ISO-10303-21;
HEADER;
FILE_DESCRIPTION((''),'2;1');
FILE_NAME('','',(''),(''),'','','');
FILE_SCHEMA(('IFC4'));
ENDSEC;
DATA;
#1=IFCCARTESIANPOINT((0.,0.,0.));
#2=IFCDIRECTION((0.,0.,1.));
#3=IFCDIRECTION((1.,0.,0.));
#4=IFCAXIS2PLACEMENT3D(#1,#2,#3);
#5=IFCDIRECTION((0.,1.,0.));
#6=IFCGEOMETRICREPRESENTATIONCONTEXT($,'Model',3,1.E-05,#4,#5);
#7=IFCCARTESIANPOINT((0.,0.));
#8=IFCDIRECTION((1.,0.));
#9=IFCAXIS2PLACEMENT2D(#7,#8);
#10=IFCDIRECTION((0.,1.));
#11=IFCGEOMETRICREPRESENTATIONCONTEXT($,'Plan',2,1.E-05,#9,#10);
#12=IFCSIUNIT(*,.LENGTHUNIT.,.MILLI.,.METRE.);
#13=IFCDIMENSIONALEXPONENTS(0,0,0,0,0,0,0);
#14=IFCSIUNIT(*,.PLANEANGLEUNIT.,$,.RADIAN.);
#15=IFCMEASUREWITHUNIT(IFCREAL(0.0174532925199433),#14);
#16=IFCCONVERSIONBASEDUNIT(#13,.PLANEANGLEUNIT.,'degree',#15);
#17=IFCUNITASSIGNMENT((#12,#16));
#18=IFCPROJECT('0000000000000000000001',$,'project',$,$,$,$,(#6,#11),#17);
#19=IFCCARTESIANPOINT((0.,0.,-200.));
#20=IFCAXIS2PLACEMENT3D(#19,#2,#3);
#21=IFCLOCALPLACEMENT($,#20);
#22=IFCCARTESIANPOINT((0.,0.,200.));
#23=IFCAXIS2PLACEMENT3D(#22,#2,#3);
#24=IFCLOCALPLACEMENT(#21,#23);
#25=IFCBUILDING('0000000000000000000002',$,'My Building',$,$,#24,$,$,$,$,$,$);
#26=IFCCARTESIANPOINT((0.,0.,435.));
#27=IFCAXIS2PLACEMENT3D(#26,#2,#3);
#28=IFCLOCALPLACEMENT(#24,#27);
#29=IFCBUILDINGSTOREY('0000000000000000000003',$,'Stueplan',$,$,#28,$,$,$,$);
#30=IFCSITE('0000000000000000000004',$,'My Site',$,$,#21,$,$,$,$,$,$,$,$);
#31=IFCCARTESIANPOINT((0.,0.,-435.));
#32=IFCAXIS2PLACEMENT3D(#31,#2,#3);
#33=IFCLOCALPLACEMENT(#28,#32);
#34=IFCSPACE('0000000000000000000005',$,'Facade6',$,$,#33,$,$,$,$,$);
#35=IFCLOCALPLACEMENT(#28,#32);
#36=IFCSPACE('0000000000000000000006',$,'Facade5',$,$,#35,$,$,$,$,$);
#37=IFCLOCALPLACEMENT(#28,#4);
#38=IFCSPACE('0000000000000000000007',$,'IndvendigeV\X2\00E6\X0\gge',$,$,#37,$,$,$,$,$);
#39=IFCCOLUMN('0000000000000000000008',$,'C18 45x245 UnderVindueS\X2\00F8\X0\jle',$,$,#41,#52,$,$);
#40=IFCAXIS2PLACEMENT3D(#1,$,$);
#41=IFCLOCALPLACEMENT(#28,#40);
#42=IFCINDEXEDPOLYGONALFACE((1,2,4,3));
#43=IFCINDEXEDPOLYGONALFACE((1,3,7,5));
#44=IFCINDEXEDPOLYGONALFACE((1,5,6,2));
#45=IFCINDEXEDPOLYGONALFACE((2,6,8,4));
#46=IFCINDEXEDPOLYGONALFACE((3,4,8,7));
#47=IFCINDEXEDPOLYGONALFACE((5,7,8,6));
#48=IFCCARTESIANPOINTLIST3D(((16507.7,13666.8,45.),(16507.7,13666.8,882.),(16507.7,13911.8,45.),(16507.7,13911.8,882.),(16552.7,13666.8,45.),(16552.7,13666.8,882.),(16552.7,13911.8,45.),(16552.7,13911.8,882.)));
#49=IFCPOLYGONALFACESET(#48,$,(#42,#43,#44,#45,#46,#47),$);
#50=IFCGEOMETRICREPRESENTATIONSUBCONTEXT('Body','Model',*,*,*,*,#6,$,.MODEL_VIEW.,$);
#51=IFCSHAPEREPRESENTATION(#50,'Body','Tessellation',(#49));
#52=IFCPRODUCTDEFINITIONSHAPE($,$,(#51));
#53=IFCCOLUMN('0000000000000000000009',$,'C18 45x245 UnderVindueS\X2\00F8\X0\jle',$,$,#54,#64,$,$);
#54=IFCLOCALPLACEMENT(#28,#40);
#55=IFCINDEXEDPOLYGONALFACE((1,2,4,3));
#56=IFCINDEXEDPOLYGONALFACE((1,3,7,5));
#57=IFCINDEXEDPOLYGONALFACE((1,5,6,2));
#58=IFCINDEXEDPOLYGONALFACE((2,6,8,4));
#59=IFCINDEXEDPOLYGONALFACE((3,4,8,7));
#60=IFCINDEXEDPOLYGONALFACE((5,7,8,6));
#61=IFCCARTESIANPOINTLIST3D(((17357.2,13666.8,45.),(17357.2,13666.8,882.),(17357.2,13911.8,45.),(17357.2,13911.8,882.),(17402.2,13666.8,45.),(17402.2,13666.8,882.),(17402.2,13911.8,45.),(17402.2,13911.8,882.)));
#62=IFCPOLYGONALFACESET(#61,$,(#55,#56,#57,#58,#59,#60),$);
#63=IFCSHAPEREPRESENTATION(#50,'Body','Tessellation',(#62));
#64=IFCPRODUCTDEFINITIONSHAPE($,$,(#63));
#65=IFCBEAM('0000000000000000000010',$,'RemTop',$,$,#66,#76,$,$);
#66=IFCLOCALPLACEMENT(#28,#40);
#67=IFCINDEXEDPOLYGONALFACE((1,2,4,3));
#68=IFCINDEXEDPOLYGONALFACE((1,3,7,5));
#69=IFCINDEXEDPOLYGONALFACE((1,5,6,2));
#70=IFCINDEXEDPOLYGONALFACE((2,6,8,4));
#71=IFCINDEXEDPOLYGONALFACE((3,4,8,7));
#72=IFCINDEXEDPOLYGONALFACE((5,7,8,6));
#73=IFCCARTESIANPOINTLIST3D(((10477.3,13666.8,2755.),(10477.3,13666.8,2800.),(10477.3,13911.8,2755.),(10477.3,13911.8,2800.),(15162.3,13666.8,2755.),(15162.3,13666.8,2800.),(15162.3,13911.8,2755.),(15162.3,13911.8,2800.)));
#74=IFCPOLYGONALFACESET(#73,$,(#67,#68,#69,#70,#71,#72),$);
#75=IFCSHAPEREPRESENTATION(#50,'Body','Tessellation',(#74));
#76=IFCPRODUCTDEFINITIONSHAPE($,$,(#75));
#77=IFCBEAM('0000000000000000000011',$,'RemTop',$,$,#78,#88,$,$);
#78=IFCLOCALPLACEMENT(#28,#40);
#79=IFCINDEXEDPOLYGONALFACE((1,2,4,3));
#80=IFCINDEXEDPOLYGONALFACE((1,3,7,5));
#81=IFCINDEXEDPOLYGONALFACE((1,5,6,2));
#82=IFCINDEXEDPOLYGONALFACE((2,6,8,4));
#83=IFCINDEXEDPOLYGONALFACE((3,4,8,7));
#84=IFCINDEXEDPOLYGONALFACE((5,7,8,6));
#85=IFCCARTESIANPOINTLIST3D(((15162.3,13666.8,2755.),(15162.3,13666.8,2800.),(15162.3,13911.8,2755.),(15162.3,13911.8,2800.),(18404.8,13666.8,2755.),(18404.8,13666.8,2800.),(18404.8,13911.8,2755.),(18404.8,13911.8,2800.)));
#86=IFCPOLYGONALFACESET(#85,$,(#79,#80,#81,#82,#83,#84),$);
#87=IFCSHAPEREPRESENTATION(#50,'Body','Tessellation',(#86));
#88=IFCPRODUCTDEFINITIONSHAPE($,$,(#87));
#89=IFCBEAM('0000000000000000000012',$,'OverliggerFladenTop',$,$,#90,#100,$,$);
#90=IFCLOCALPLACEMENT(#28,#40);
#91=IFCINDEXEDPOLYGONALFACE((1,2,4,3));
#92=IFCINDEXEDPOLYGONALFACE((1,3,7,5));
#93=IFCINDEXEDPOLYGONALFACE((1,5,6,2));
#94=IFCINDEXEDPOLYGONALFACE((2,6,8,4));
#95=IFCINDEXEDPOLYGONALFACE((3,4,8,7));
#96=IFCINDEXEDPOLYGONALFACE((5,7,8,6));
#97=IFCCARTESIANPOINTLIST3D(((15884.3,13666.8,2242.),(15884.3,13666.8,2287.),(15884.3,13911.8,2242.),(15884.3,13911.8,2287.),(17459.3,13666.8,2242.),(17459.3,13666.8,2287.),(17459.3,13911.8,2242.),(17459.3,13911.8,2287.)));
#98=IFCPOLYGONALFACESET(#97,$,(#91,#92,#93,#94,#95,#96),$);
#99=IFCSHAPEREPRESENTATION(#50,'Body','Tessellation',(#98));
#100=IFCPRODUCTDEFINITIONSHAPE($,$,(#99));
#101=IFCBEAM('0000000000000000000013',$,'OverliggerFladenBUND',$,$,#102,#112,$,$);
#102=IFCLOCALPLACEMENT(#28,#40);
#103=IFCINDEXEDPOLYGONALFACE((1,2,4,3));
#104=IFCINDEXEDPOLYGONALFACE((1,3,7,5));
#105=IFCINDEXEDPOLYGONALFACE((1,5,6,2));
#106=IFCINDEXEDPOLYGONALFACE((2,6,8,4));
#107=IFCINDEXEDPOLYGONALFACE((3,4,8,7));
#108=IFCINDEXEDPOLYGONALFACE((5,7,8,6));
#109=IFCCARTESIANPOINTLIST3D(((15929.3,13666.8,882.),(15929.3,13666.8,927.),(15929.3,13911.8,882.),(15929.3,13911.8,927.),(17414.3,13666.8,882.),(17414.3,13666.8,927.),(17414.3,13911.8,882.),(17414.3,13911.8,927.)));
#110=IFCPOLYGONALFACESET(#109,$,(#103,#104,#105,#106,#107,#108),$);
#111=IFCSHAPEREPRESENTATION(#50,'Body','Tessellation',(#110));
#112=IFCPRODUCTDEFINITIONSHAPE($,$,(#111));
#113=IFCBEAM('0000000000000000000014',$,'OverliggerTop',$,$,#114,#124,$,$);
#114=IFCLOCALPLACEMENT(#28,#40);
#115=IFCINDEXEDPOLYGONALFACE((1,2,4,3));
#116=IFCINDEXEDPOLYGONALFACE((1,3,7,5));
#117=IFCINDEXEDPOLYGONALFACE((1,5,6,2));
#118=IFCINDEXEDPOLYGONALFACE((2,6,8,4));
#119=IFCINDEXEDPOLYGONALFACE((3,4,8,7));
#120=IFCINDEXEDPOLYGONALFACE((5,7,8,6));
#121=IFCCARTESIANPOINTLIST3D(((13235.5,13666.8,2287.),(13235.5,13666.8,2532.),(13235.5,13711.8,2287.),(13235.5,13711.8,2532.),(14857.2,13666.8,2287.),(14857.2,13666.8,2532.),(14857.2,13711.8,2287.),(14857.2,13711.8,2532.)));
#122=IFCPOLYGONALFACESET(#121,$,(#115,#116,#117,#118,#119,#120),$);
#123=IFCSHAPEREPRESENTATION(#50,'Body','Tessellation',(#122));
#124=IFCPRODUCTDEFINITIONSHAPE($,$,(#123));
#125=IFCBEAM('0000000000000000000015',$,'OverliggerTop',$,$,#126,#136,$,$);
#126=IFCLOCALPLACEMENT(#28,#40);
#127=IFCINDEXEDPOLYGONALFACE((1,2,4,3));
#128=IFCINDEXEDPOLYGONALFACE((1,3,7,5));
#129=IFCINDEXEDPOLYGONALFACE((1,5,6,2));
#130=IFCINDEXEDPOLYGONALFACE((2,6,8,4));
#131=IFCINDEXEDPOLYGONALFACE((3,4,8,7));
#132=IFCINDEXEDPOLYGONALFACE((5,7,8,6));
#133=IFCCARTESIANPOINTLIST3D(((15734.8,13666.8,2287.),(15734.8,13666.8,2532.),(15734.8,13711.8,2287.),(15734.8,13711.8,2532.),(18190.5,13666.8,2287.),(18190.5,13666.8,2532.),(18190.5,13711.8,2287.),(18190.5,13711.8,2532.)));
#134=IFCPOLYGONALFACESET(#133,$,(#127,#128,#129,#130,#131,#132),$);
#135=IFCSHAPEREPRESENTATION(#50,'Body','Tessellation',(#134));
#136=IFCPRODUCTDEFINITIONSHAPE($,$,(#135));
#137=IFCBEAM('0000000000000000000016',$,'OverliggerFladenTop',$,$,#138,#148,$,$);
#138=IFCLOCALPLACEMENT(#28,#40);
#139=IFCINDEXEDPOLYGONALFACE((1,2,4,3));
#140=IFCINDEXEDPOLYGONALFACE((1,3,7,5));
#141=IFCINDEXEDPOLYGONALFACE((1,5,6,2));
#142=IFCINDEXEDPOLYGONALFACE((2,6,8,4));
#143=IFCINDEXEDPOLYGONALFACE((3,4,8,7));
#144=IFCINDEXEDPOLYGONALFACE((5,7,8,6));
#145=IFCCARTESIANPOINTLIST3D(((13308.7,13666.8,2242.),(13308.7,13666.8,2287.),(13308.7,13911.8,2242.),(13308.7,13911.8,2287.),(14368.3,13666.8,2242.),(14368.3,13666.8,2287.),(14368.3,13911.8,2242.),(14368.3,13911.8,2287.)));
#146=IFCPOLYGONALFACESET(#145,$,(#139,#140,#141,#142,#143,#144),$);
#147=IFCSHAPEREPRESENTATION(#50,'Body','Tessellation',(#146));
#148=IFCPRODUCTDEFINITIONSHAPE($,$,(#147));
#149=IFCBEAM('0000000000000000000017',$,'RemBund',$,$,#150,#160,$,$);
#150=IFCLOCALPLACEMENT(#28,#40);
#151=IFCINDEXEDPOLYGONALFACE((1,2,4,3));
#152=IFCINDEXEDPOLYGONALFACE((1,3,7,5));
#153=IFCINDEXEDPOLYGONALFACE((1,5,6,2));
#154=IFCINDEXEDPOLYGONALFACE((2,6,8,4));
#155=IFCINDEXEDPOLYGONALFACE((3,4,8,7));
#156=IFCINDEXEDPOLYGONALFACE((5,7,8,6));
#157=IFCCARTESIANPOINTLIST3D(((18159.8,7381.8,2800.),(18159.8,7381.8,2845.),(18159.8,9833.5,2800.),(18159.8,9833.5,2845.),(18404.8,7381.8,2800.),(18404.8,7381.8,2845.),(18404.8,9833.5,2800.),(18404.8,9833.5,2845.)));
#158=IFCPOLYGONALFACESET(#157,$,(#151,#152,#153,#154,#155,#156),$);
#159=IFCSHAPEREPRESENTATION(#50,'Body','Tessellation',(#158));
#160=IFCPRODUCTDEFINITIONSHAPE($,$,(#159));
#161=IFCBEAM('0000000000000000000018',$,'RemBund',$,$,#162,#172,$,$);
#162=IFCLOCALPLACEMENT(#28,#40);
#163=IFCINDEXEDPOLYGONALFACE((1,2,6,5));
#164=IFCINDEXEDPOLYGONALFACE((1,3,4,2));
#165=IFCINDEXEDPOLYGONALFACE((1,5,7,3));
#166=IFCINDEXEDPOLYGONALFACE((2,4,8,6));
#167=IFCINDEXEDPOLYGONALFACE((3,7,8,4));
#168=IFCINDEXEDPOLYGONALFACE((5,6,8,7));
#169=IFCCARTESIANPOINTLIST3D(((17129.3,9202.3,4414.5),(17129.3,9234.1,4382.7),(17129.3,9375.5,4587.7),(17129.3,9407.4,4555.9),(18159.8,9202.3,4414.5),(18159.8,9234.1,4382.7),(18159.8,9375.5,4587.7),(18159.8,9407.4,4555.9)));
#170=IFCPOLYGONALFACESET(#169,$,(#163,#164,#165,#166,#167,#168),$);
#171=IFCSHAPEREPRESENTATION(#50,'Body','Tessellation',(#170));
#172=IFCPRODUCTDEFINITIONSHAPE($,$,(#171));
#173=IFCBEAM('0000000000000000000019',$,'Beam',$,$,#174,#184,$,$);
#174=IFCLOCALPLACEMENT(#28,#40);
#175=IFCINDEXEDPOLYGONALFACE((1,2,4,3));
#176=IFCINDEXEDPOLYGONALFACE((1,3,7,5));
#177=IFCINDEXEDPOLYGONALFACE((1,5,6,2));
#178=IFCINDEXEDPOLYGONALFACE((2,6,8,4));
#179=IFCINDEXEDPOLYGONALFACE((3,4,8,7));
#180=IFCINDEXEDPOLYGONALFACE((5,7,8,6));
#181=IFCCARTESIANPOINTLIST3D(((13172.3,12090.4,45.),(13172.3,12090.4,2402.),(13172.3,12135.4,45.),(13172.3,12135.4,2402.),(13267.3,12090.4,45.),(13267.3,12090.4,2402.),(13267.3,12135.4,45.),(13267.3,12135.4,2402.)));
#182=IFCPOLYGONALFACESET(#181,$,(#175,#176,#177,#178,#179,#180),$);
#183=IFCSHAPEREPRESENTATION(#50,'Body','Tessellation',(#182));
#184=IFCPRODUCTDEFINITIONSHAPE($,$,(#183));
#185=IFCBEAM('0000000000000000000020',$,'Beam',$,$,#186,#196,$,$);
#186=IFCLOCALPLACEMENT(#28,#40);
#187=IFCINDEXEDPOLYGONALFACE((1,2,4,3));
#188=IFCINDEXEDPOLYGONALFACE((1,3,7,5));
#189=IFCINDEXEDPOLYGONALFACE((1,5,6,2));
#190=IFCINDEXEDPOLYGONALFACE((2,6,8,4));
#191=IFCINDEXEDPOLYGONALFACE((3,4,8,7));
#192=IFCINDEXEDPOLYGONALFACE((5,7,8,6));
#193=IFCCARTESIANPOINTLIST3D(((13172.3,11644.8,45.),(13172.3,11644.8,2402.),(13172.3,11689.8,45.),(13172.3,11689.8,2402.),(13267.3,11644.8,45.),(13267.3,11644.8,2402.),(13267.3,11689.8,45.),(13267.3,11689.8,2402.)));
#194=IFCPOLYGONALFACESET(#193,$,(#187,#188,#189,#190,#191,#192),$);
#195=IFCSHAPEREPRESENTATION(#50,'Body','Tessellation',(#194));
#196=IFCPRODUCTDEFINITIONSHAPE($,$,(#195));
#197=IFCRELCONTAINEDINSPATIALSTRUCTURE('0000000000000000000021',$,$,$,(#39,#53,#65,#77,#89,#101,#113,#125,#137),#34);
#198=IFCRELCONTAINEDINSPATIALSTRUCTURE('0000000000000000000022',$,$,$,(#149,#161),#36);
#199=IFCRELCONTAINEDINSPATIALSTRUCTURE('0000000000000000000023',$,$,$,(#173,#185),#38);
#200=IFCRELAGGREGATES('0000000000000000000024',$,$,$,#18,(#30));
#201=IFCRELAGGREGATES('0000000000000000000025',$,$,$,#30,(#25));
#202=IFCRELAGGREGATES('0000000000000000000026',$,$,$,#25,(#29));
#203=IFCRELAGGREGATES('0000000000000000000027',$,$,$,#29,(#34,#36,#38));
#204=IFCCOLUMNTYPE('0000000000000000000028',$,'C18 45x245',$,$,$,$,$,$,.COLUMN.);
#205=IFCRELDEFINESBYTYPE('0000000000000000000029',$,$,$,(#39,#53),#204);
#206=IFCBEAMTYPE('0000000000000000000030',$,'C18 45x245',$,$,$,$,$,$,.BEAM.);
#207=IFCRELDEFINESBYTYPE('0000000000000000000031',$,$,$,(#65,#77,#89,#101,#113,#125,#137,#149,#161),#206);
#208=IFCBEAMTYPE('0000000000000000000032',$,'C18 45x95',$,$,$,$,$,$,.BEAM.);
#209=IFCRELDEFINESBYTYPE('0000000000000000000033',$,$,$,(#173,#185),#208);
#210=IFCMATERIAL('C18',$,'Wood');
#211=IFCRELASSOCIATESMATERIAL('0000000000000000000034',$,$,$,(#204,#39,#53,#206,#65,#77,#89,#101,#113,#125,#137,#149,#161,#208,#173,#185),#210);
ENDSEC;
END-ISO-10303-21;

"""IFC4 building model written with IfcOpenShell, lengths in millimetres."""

from ifc_helpers import new_model, entity, si_unit, converted_unit, direction, frame, origin_with_axes, origin_2d_with_axis, place, context, subcontext, project, spatial, rectangle, extrude, material, material_profile, profile_set, profile_usage, type_object, element, save


model = new_model("IFC4")

# Units and contexts
model_context = context("Model", 3, precision=1e-05, world=origin_with_axes(), true_north=direction((0.0, 1.0, 0.0)))
plan_context = context("Plan", 2, precision=1e-05, world=origin_2d_with_axis(), true_north=direction((0.0, 1.0)))
body_context_1 = subcontext(model_context, "Body", "Model", "MODEL_VIEW")
ifc_project = project(units=[si_unit("LENGTHUNIT", "METRE", prefix="MILLI"), converted_unit("PLANEANGLEUNIT", "degree", entity("IfcReal", 0.0174532925199433), si_unit("PLANEANGLEUNIT", "RADIAN"), dimensions=[0, 0, 0, 0, 0, 0, 0])], contexts=[model_context, plan_context])

# Site, building, storey, space
site_placement = place(None, frame((0.0, 0.0, -200.0), z_axis=(0.0, 0.0, 1.0), x_axis=(1.0, 0.0, 0.0)))
site = spatial("IfcSite", under=ifc_project, at=site_placement, Name="My Site")
building_placement = place(site_placement, frame((0.0, 0.0, 200.0), z_axis=(0.0, 0.0, 1.0), x_axis=(1.0, 0.0, 0.0)))
building = spatial("IfcBuilding", under=site, at=building_placement, Name="My Building")
storey_placement = place(building_placement, frame((0.0, 0.0, 435.0), z_axis=(0.0, 0.0, 1.0), x_axis=(1.0, 0.0, 0.0)))
storey = spatial("IfcBuildingStorey", under=building, at=storey_placement, Name="Stueplan")
space_1_placement = place(storey_placement, frame((0.0, 0.0, -435.0), z_axis=(0.0, 0.0, 1.0), x_axis=(1.0, 0.0, 0.0)))
space_1 = spatial("IfcSpace", under=storey, at=space_1_placement, Name="Facade6")

# Shared definitions
ifc_material = material(Name="C18", Category="Wood")
ifc_material_profile_1 = material_profile(ifc_material, rectangle(XDim=45.0, YDim=245.0))
ifc_profile_set_1 = profile_set([ifc_material_profile_1], Name="woodStructural")
column_type = type_object("IfcColumnType", Name="C18 45x245", PredefinedType="COLUMN", material=ifc_profile_set_1)

# Shared definitions
space_2_placement = place(storey_placement, frame((0.0, 0.0, -435.0), z_axis=(0.0, 0.0, 1.0), x_axis=(1.0, 0.0, 0.0)))
space_2 = spatial("IfcSpace", under=storey, at=space_2_placement, Name="Facade5")

# Columns
ifc_profile_usage_1 = profile_usage(ifc_profile_set_1, cardinal=9)
column_1_placement = place(space_1_placement, frame((16507.7, 13911.8, 480.0), z_axis=(0.0, 0.0, 1.0), x_axis=(1.0, 0.0, 0.0)))
element("IfcColumn", 1, at=column_1_placement, inside=space_1, type_object=column_type, material=ifc_profile_usage_1, Name="C18 45x245 UnderVindueSøjle", context=body_context_1, shape_type="SweptSolid", body=[
    extrude(rectangle(XDim=45.0, YDim=245.0), frame((22.5, -122.5, 0.0), z_axis=(0.0, 0.0, 1.0), x_axis=(1.0, 0.0, 0.0)), (0.0, 0.0, 1.0), 837.0),
])
ifc_profile_usage_2 = profile_usage(ifc_profile_set_1, cardinal=9)
column_2_placement = place(space_1_placement, frame((17357.2, 13911.8, 480.0), z_axis=(0.0, 0.0, 1.0), x_axis=(1.0, 0.0, 0.0)))
element("IfcColumn", 2, at=column_2_placement, inside=space_1, type_object=column_type, material=ifc_profile_usage_2, Name="C18 45x245 UnderVindueSøjle", context=body_context_1, shape_type="SweptSolid", body=[
    extrude(rectangle(XDim=45.0, YDim=245.0), frame((22.5, -122.5, 0.0), z_axis=(0.0, 0.0, 1.0), x_axis=(1.0, 0.0, 0.0)), (0.0, 0.0, 1.0), 837.0),
])

# Beams
ifc_material_profile_2 = material_profile(ifc_material, rectangle(XDim=45.0, YDim=245.0), Name="concrete")
ifc_profile_set_2 = profile_set([ifc_material_profile_2], Name="woodStructural")
ifc_profile_usage_3 = profile_usage(ifc_profile_set_2)
beam_type_1 = type_object("IfcBeamType", Name="C18 45x245", PredefinedType="BEAM", material=ifc_profile_set_2)
beam_1_placement = place(space_1_placement, frame((15162.3, 13789.3, 3212.5), z_axis=(-1.0, 0.0, 0.0), x_axis=(0.0, 0.0, 1.0)))
element("IfcBeam", 3, at=beam_1_placement, inside=space_1, type_object=beam_type_1, material=ifc_profile_usage_3, Name="RemTop", context=body_context_1, shape_type="SweptSolid", body=[
    extrude(rectangle(XDim=45.0, YDim=245.0), origin_with_axes(), (0.0, 0.0, 1.0), 4685.0),
])
ifc_profile_usage_4 = profile_usage(ifc_profile_set_2)
beam_2_placement = place(space_1_placement, frame((18404.8, 13789.3, 3212.5), z_axis=(-1.0, 0.0, 0.0), x_axis=(0.0, 0.0, 1.0)))
element("IfcBeam", 4, at=beam_2_placement, inside=space_1, type_object=beam_type_1, material=ifc_profile_usage_4, Name="RemTop", context=body_context_1, shape_type="SweptSolid", body=[
    extrude(rectangle(XDim=45.0, YDim=245.0), origin_with_axes(), (0.0, 0.0, 1.0), 3242.5),
])
ifc_profile_usage_5 = profile_usage(ifc_profile_set_2)
beam_3_placement = place(space_1_placement, frame((17459.3, 13789.3, 2699.5), z_axis=(-1.0, 0.0, 0.0), x_axis=(0.0, 0.0, 1.0)))
element("IfcBeam", 5, at=beam_3_placement, inside=space_1, type_object=beam_type_1, material=ifc_profile_usage_5, Name="OverliggerFladenTop", context=body_context_1, shape_type="SweptSolid", body=[
    extrude(rectangle(XDim=45.0, YDim=245.0), origin_with_axes(), (0.0, 0.0, 1.0), 1575.0),
])
ifc_profile_usage_6 = profile_usage(ifc_profile_set_2)
beam_4_placement = place(space_1_placement, frame((17414.3, 13789.3, 1339.5), z_axis=(-1.0, 0.0, 0.0), x_axis=(0.0, 0.0, 1.0)))
element("IfcBeam", 6, at=beam_4_placement, inside=space_1, type_object=beam_type_1, material=ifc_profile_usage_6, Name="OverliggerFladenBUND", context=body_context_1, shape_type="SweptSolid", body=[
    extrude(rectangle(XDim=45.0, YDim=245.0), origin_with_axes(), (0.0, 0.0, 1.0), 1485.0),
])
ifc_profile_usage_7 = profile_usage(ifc_profile_set_2)
beam_5_placement = place(space_1_placement, frame((13235.5, 13689.3, 2844.5), z_axis=(1.0, 0.0, 0.0), x_axis=(0.0, -1.0, 0.0)))
element("IfcBeam", 7, at=beam_5_placement, inside=space_1, type_object=beam_type_1, material=ifc_profile_usage_7, Name="OverliggerTop", context=body_context_1, shape_type="SweptSolid", body=[
    extrude(rectangle(XDim=45.0, YDim=245.0), origin_with_axes(), (0.0, 0.0, 1.0), 1621.7),
])
ifc_profile_usage_8 = profile_usage(ifc_profile_set_2)
beam_6_placement = place(space_1_placement, frame((15734.8, 13689.3, 2844.5), z_axis=(1.0, 0.0, 0.0), x_axis=(0.0, -1.0, 0.0)))
element("IfcBeam", 8, at=beam_6_placement, inside=space_1, type_object=beam_type_1, material=ifc_profile_usage_8, Name="OverliggerTop", context=body_context_1, shape_type="SweptSolid", body=[
    extrude(rectangle(XDim=45.0, YDim=245.0), origin_with_axes(), (0.0, 0.0, 1.0), 2455.7),
])
ifc_profile_usage_9 = profile_usage(ifc_profile_set_2)
beam_7_placement = place(space_1_placement, frame((14368.3, 13789.3, 2699.5), z_axis=(-1.0, 0.0, 0.0), x_axis=(0.0, 0.0, 1.0)))
element("IfcBeam", 9, at=beam_7_placement, inside=space_1, type_object=beam_type_1, material=ifc_profile_usage_9, Name="OverliggerFladenTop", context=body_context_1, shape_type="SweptSolid", body=[
    extrude(rectangle(XDim=45.0, YDim=245.0), origin_with_axes(), (0.0, 0.0, 1.0), 1059.5),
])
ifc_profile_usage_10 = profile_usage(ifc_profile_set_2)
beam_8_placement = place(space_2_placement, frame((18282.3, 9833.5, 3257.5), z_axis=(0.0, -1.0, 0.0), x_axis=(0.0, 0.0, 1.0)))
element("IfcBeam", 10, at=beam_8_placement, inside=space_2, type_object=beam_type_1, material=ifc_profile_usage_10, Name="RemBund", context=body_context_1, shape_type="SweptSolid", body=[
    extrude(rectangle(XDim=45.0, YDim=245.0), origin_with_axes(), (0.0, 0.0, 1.0), 2451.7),
])
ifc_profile_usage_11 = profile_usage(ifc_profile_set_2)
beam_9_placement = place(space_2_placement, frame((17129.3, 9304.8, 4920.2), z_axis=(1.0, 0.0, 0.0), x_axis=(0.0, -0.707107, 0.707107)))
element("IfcBeam", 11, at=beam_9_placement, inside=space_2, type_object=beam_type_1, material=ifc_profile_usage_11, Name="RemBund", context=body_context_1, shape_type="SweptSolid", body=[
    extrude(rectangle(XDim=45.0, YDim=245.0), origin_with_axes(), (0.0, 0.0, 1.0), 1030.5),
])

# Shared definitions
space_3_placement = place(storey_placement, frame((0.0, 0.0, 0.0), z_axis=(0.0, 0.0, 1.0), x_axis=(1.0, 0.0, 0.0)))
space_3 = spatial("IfcSpace", under=storey, at=space_3_placement, Name="IndvendigeVægge")

# Beams
ifc_material_profile_3 = material_profile(ifc_material, rectangle(XDim=45.0, YDim=95.0))
ifc_profile_set_3 = profile_set([ifc_material_profile_3], Name="woodStructural")
ifc_profile_usage_12 = profile_usage(ifc_profile_set_3)
beam_type_2 = type_object("IfcBeamType", Name="C18 45x95", PredefinedType="BEAM", material=ifc_profile_set_3)
beam_10_placement = place(space_3_placement, frame((13219.8, 12112.9, 45.0), z_axis=(0.0, 0.0, 1.0), x_axis=(0.0, -1.0, 0.0)))
element("IfcBeam", 12, at=beam_10_placement, inside=space_3, type_object=beam_type_2, material=ifc_profile_usage_12, Name="Beam", context=body_context_1, shape_type="SweptSolid", body=[
    extrude(rectangle(XDim=45.0, YDim=95.0), origin_with_axes(), (0.0, 0.0, 1.0), 2357.0),
])
ifc_profile_usage_13 = profile_usage(ifc_profile_set_3)
beam_11_placement = place(space_3_placement, frame((13219.8, 11667.3, 45.0), z_axis=(0.0, 0.0, 1.0), x_axis=(0.0, -1.0, 0.0)))
element("IfcBeam", 13, at=beam_11_placement, inside=space_3, type_object=beam_type_2, material=ifc_profile_usage_13, Name="Beam", context=body_context_1, shape_type="SweptSolid", body=[
    extrude(rectangle(XDim=45.0, YDim=95.0), origin_with_axes(), (0.0, 0.0, 1.0), 2357.0),
])

save(model, "model.ifc")
